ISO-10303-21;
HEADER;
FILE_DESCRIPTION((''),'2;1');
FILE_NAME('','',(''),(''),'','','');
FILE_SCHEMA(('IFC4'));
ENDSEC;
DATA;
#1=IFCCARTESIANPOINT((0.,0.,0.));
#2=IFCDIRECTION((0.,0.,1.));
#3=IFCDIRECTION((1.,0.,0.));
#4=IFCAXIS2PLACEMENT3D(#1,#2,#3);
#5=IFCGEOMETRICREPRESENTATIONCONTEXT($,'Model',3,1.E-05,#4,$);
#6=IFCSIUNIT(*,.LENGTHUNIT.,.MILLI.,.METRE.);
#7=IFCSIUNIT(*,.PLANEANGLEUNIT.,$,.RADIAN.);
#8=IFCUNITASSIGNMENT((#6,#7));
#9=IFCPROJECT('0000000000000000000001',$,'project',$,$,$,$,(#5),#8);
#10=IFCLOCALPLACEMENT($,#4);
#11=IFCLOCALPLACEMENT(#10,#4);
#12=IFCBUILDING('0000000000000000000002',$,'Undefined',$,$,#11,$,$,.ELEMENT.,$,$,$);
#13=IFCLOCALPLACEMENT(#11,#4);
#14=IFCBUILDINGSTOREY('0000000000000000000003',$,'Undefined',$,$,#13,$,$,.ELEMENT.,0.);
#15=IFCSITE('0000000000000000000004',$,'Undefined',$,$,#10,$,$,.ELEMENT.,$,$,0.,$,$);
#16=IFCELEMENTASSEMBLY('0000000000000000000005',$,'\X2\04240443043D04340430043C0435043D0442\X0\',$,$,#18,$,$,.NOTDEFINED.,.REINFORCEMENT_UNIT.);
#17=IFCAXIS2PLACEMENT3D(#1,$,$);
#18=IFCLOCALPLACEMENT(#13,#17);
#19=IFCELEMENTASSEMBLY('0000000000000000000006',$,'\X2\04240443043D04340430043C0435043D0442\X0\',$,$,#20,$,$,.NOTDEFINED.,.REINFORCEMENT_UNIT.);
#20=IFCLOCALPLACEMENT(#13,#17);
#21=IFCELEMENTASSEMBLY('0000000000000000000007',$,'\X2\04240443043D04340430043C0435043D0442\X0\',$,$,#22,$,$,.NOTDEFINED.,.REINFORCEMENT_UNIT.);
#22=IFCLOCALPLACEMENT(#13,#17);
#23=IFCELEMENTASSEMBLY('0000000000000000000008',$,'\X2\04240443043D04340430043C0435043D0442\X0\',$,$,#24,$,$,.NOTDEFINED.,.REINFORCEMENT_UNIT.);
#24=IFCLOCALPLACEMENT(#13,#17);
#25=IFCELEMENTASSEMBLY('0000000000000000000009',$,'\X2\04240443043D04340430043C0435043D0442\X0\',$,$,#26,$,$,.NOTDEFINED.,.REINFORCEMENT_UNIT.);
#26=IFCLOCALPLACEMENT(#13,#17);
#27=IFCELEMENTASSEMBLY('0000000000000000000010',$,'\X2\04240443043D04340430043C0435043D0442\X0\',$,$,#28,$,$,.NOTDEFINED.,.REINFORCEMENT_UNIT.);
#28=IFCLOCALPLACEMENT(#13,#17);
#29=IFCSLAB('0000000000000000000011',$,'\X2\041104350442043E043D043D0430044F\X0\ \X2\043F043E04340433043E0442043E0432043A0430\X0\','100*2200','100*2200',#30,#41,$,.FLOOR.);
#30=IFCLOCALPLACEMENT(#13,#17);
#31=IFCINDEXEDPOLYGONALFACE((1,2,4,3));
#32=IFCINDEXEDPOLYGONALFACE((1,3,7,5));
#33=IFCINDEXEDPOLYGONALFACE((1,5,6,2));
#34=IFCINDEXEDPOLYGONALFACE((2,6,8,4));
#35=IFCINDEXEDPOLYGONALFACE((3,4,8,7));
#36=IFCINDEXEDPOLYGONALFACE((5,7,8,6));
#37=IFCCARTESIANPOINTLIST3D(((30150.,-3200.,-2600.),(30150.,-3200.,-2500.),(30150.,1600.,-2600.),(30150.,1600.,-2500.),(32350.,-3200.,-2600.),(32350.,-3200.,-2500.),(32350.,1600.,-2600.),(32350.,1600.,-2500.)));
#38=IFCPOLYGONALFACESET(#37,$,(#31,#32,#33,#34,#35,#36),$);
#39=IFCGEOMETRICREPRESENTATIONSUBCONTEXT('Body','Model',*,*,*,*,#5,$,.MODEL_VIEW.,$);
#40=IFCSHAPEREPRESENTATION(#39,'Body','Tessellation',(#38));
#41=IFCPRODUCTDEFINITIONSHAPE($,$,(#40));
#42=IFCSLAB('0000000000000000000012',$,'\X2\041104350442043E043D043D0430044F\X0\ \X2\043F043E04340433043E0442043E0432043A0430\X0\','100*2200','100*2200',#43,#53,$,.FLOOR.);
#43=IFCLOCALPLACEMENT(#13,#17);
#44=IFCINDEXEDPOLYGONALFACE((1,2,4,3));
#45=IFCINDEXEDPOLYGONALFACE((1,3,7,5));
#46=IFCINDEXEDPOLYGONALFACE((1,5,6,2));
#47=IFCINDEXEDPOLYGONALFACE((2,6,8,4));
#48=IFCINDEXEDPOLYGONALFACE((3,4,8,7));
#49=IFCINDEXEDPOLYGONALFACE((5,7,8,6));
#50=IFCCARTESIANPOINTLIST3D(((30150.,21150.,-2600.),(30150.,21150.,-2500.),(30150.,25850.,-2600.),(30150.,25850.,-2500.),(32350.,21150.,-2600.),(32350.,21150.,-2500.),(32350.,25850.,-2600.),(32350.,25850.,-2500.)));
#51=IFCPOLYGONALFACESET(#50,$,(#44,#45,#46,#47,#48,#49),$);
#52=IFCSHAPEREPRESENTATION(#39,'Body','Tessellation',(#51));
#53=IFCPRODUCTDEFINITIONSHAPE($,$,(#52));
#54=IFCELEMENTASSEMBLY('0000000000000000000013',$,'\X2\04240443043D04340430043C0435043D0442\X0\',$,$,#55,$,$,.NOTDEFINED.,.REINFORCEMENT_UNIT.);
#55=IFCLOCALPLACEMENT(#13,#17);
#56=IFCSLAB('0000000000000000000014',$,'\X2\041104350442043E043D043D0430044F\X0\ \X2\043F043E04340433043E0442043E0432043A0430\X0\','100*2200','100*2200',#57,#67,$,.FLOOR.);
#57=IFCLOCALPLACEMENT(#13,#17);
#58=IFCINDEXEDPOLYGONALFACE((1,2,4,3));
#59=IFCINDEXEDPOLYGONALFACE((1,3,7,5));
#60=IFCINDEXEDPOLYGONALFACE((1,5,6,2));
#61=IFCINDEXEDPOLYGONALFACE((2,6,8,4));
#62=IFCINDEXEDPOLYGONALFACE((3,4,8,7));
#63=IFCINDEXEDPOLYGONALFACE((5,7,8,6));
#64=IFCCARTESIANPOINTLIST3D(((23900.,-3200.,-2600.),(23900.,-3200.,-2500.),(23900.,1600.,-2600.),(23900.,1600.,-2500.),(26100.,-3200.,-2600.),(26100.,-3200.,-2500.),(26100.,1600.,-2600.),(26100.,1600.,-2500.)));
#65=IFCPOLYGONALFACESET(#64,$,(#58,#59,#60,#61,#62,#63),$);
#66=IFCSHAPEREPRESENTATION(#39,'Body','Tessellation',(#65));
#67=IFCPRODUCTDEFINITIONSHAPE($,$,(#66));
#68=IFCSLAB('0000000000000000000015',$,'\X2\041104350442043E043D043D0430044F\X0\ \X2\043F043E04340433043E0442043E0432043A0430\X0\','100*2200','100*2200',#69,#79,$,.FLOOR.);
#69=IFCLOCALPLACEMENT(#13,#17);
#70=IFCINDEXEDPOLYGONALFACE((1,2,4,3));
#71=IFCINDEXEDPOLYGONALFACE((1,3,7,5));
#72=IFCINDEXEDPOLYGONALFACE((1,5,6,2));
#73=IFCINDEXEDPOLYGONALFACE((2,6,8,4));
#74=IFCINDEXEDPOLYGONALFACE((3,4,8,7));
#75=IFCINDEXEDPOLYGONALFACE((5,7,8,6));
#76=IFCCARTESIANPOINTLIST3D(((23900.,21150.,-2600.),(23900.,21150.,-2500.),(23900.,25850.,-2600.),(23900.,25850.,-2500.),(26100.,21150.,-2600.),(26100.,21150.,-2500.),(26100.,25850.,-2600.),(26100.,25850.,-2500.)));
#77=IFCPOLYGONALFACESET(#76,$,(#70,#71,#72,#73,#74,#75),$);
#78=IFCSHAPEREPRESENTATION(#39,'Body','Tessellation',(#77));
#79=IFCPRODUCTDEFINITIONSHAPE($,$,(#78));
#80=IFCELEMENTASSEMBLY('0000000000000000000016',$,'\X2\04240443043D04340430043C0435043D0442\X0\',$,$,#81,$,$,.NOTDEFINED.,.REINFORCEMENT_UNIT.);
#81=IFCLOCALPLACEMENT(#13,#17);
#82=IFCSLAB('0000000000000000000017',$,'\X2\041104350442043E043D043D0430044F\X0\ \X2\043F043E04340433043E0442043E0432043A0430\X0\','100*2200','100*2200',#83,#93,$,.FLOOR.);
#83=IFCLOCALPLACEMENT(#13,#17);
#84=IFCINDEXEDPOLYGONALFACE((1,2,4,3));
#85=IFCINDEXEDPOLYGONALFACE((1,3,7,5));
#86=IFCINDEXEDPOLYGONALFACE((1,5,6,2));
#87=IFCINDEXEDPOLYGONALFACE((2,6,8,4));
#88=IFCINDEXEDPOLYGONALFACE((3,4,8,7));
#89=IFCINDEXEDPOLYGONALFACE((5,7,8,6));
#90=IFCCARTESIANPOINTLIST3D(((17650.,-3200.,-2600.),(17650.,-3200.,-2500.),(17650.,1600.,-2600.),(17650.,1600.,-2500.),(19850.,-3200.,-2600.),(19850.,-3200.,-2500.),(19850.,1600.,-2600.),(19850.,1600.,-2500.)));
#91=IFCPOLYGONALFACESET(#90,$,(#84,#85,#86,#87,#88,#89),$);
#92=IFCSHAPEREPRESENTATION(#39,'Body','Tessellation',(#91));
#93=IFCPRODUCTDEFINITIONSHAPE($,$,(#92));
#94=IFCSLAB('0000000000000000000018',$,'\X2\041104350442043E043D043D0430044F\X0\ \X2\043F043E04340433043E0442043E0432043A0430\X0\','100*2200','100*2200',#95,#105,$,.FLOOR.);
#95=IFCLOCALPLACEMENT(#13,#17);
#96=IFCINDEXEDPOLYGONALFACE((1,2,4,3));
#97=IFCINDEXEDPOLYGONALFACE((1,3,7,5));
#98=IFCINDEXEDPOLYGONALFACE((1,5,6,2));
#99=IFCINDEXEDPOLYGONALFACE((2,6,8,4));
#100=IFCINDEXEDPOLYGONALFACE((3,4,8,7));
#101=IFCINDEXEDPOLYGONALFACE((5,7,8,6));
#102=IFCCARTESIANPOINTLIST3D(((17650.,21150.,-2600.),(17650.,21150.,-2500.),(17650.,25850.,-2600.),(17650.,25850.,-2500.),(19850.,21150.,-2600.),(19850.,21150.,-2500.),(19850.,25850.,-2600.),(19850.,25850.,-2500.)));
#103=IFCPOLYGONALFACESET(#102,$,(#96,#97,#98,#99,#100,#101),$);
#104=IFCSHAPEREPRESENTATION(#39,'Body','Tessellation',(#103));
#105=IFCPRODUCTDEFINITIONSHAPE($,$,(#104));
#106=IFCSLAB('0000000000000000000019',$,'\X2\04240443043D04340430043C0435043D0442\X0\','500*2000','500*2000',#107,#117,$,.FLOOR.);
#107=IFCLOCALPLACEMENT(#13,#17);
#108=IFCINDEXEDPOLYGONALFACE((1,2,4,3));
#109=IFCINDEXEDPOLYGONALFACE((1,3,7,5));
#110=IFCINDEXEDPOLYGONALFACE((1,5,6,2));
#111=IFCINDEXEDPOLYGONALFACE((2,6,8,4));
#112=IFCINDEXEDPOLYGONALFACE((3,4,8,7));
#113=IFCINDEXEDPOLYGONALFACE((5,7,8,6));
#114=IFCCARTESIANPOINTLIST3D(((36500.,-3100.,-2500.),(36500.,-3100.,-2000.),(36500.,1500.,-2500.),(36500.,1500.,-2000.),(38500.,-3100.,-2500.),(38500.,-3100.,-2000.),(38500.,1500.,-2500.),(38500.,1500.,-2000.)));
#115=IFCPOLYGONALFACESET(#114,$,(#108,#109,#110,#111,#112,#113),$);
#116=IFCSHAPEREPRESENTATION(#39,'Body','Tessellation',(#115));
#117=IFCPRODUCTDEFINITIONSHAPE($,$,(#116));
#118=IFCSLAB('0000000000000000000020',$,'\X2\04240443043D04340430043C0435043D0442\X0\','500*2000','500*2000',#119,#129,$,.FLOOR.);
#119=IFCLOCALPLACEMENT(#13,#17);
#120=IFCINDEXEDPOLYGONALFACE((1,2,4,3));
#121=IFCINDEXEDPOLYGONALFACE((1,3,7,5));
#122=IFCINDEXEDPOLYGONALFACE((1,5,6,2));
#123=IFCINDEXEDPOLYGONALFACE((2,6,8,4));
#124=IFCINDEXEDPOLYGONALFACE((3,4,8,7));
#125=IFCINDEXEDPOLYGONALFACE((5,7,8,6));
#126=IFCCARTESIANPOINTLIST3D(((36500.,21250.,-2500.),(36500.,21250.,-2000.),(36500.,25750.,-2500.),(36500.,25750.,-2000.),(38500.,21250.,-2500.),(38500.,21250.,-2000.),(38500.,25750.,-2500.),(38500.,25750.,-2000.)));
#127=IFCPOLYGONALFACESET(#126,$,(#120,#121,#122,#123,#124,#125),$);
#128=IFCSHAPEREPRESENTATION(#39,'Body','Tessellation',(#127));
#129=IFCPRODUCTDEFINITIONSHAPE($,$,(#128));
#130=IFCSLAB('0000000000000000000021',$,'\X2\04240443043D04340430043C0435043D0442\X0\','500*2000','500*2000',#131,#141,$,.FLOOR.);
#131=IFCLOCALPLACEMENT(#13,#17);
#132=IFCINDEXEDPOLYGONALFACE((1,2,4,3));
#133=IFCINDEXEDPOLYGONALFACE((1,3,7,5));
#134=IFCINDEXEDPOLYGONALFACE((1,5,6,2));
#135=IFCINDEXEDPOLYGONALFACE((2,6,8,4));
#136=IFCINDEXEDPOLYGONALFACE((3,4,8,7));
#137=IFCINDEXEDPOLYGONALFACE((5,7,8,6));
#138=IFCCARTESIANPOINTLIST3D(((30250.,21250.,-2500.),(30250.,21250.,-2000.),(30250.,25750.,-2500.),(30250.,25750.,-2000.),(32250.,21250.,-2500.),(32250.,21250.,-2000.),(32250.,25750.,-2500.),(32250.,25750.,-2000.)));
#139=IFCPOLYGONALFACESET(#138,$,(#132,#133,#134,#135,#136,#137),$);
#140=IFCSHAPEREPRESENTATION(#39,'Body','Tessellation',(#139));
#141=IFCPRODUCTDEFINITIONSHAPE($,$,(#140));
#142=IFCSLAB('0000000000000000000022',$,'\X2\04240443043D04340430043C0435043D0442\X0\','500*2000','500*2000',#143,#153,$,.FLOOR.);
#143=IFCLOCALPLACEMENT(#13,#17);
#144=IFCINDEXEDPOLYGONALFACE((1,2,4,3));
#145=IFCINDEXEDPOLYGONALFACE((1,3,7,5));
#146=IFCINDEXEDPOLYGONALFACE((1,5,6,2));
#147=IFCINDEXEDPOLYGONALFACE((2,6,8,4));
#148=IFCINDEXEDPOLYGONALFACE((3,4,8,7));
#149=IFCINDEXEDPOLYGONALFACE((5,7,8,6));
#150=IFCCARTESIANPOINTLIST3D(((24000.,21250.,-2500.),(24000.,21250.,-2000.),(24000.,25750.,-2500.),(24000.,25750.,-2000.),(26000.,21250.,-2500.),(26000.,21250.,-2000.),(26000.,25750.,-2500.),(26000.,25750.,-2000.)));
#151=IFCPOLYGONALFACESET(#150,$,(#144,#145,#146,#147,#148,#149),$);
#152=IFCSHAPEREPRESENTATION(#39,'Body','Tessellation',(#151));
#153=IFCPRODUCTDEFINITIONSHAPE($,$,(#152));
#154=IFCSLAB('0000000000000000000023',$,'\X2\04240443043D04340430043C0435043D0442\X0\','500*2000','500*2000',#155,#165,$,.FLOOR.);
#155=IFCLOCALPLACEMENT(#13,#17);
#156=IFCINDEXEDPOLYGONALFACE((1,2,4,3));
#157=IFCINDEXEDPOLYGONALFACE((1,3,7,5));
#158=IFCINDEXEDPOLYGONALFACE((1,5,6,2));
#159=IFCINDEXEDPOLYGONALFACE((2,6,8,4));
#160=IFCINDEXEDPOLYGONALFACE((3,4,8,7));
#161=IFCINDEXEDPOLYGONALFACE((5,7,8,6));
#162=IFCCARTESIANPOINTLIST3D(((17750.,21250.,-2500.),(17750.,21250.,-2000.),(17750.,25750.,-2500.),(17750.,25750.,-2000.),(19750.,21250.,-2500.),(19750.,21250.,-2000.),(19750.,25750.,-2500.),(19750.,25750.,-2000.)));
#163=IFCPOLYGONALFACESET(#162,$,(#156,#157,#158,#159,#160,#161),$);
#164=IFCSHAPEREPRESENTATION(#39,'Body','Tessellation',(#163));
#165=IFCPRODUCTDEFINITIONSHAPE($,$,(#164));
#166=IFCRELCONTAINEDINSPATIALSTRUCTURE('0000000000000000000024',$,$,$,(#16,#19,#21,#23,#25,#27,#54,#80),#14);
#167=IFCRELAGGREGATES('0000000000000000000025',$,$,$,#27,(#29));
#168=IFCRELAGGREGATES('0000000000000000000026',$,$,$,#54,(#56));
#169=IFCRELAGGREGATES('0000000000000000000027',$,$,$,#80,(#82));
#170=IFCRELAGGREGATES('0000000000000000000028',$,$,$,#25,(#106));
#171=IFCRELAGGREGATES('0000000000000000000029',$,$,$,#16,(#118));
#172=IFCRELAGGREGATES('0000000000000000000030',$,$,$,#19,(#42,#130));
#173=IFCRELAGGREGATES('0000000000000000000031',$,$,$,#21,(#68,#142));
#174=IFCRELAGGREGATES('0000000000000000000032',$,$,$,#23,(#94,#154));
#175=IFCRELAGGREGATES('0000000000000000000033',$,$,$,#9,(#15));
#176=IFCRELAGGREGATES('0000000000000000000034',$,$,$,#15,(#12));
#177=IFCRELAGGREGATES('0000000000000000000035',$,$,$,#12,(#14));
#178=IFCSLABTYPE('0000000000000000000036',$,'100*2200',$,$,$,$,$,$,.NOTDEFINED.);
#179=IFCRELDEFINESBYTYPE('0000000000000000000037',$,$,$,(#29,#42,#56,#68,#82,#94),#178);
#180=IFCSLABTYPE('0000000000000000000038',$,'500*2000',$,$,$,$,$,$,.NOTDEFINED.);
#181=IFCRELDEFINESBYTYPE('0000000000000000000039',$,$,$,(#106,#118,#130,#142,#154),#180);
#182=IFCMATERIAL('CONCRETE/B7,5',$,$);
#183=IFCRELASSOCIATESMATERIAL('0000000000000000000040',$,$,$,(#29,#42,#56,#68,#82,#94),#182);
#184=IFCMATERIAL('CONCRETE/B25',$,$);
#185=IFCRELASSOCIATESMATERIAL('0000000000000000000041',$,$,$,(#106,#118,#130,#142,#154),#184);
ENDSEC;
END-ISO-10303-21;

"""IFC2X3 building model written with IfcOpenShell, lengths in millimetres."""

from ifc_helpers import new_model, si_unit, frame, origin_with_axes, place, context, subcontext, project, spatial, polyline, outline, extrude, material, type_object, element, aggregate, save


model = new_model("IFC2X3")

# Units and contexts
model_context = context("Model", 3, precision=1e-05, world=origin_with_axes())
body_context = subcontext(model_context, "Body", "Model", "MODEL_VIEW")
ifc_project = project(units=[si_unit("LENGTHUNIT", "METRE", prefix="MILLI"), si_unit("PLANEANGLEUNIT", "RADIAN")], contexts=[model_context])

# Site, building, storey
site_placement = place(None, origin_with_axes())
site = spatial("IfcSite", under=ifc_project, at=site_placement, Name="Undefined", CompositionType="ELEMENT", RefElevation=0.0)
building_placement = place(site_placement, origin_with_axes())
building = spatial("IfcBuilding", under=site, at=building_placement, Name="Undefined", CompositionType="ELEMENT")
storey_placement = place(building_placement, origin_with_axes())
storey = spatial("IfcBuildingStorey", under=building, at=storey_placement, Name="Undefined", CompositionType="ELEMENT", Elevation=0.0)

# Element assemblies
ifc_material_1 = material(Name="CONCRETE/B25")
assembly_1_placement = place(storey_placement, origin_with_axes())
assembly_1 = element("IfcElementAssembly", 1, at=assembly_1_placement, inside=storey, Name="Фундамент", AssemblyPlace="NOTDEFINED", PredefinedType="REINFORCEMENT_UNIT")
assembly_2_placement = place(storey_placement, origin_with_axes())
assembly_2 = element("IfcElementAssembly", 2, at=assembly_2_placement, inside=storey, Name="Фундамент", AssemblyPlace="NOTDEFINED", PredefinedType="REINFORCEMENT_UNIT")
assembly_3_placement = place(storey_placement, origin_with_axes())
assembly_3 = element("IfcElementAssembly", 3, at=assembly_3_placement, inside=storey, Name="Фундамент", AssemblyPlace="NOTDEFINED", PredefinedType="REINFORCEMENT_UNIT")
assembly_4_placement = place(storey_placement, origin_with_axes())
assembly_4 = element("IfcElementAssembly", 4, at=assembly_4_placement, inside=storey, Name="Фундамент", AssemblyPlace="NOTDEFINED", PredefinedType="REINFORCEMENT_UNIT")

# Element assembly
assembly_5_placement = place(storey_placement, origin_with_axes())
assembly_5 = element("IfcElementAssembly", 5, at=assembly_5_placement, inside=storey, Name="Фундамент", AssemblyPlace="NOTDEFINED", PredefinedType="REINFORCEMENT_UNIT")
ifc_material_2 = material(Name="CONCRETE/B7,5")
slab_type_1 = type_object("IfcSlabType", Name="100*2200", PredefinedType="NOTDEFINED")

# Element assembly, slab
assembly_6_placement = place(storey_placement, origin_with_axes())
assembly_6 = element("IfcElementAssembly", 6, at=assembly_6_placement, inside=storey, Name="Фундамент", AssemblyPlace="NOTDEFINED", PredefinedType="REINFORCEMENT_UNIT")
slab_1_placement = place(assembly_6_placement, frame((30150.0, 1600.0, -2550.0), z_axis=(0.0, 0.0, 1.0), x_axis=(0.0, -1.0, 0.0)))
slab_1 = element("IfcSlab", 7, at=slab_1_placement, type_object=slab_type_1, material=ifc_material_2, Name="Бетонная подготовка", Description="100*2200", ObjectType="100*2200", PredefinedType="FLOOR", context=body_context, shape_type="SweptSolid", body=[
    extrude(outline(polyline([(0.0, 0.0), (4800.0, 0.0), (4800.0, 2200.0), (0.0, 2200.0), (0.0, 0.0)])), frame((0.0, 0.0, -50.0), z_axis=(0.0, 0.0, 1.0), x_axis=(1.0, 0.0, 0.0)), (0.0, 0.0, 1.0), 100.0),
])
aggregate(assembly_6, [slab_1])

# Slab
slab_2_placement = place(assembly_2_placement, frame((30150.0, 25850.0, -2550.0), z_axis=(0.0, 0.0, 1.0), x_axis=(0.0, -1.0, 0.0)))
slab_2 = element("IfcSlab", 8, at=slab_2_placement, type_object=slab_type_1, material=ifc_material_2, Name="Бетонная подготовка", Description="100*2200", ObjectType="100*2200", PredefinedType="FLOOR", context=body_context, shape_type="SweptSolid", body=[
    extrude(outline(polyline([(0.0, 0.0), (4700.0, 0.0), (4700.0, 2200.0), (0.0, 2200.0), (0.0, 0.0)])), frame((0.0, 0.0, -50.0), z_axis=(0.0, 0.0, 1.0), x_axis=(1.0, 0.0, 0.0)), (0.0, 0.0, 1.0), 100.0),
])

# Element assembly, slab
assembly_7_placement = place(storey_placement, origin_with_axes())
assembly_7 = element("IfcElementAssembly", 9, at=assembly_7_placement, inside=storey, Name="Фундамент", AssemblyPlace="NOTDEFINED", PredefinedType="REINFORCEMENT_UNIT")
slab_3_placement = place(assembly_7_placement, frame((23900.0, 1600.0, -2550.0), z_axis=(0.0, 0.0, 1.0), x_axis=(0.0, -1.0, 0.0)))
slab_3 = element("IfcSlab", 10, at=slab_3_placement, type_object=slab_type_1, material=ifc_material_2, Name="Бетонная подготовка", Description="100*2200", ObjectType="100*2200", PredefinedType="FLOOR", context=body_context, shape_type="SweptSolid", body=[
    extrude(outline(polyline([(0.0, 0.0), (4800.0, 0.0), (4800.0, 2200.0), (0.0, 2200.0), (0.0, 0.0)])), frame((0.0, 0.0, -50.0), z_axis=(0.0, 0.0, 1.0), x_axis=(1.0, 0.0, 0.0)), (0.0, 0.0, 1.0), 100.0),
])
aggregate(assembly_7, [slab_3])

# Slab
slab_4_placement = place(assembly_3_placement, frame((23900.0, 25850.0, -2550.0), z_axis=(0.0, 0.0, 1.0), x_axis=(0.0, -1.0, 0.0)))
slab_4 = element("IfcSlab", 11, at=slab_4_placement, type_object=slab_type_1, material=ifc_material_2, Name="Бетонная подготовка", Description="100*2200", ObjectType="100*2200", PredefinedType="FLOOR", context=body_context, shape_type="SweptSolid", body=[
    extrude(outline(polyline([(0.0, 0.0), (4700.0, 0.0), (4700.0, 2200.0), (0.0, 2200.0), (0.0, 0.0)])), frame((0.0, 0.0, -50.0), z_axis=(0.0, 0.0, 1.0), x_axis=(1.0, 0.0, 0.0)), (0.0, 0.0, 1.0), 100.0),
])

# Element assembly, slab
assembly_8_placement = place(storey_placement, origin_with_axes())
assembly_8 = element("IfcElementAssembly", 12, at=assembly_8_placement, inside=storey, Name="Фундамент", AssemblyPlace="NOTDEFINED", PredefinedType="REINFORCEMENT_UNIT")
slab_5_placement = place(assembly_8_placement, frame((17650.0, 1600.0, -2550.0), z_axis=(0.0, 0.0, 1.0), x_axis=(0.0, -1.0, 0.0)))
slab_5 = element("IfcSlab", 13, at=slab_5_placement, type_object=slab_type_1, material=ifc_material_2, Name="Бетонная подготовка", Description="100*2200", ObjectType="100*2200", PredefinedType="FLOOR", context=body_context, shape_type="SweptSolid", body=[
    extrude(outline(polyline([(0.0, 0.0), (4800.0, 0.0), (4800.0, 2200.0), (0.0, 2200.0), (0.0, 0.0)])), frame((0.0, 0.0, -50.0), z_axis=(0.0, 0.0, 1.0), x_axis=(1.0, 0.0, 0.0)), (0.0, 0.0, 1.0), 100.0),
])
aggregate(assembly_8, [slab_5])

# Slabs
slab_6_placement = place(assembly_4_placement, frame((17650.0, 25850.0, -2550.0), z_axis=(0.0, 0.0, 1.0), x_axis=(0.0, -1.0, 0.0)))
slab_6 = element("IfcSlab", 14, at=slab_6_placement, type_object=slab_type_1, material=ifc_material_2, Name="Бетонная подготовка", Description="100*2200", ObjectType="100*2200", PredefinedType="FLOOR", context=body_context, shape_type="SweptSolid", body=[
    extrude(outline(polyline([(0.0, 0.0), (4700.0, 0.0), (4700.0, 2200.0), (0.0, 2200.0), (0.0, 0.0)])), frame((0.0, 0.0, -50.0), z_axis=(0.0, 0.0, 1.0), x_axis=(1.0, 0.0, 0.0)), (0.0, 0.0, 1.0), 100.0),
])
slab_type_2 = type_object("IfcSlabType", Name="500*2000", PredefinedType="NOTDEFINED")
slab_7_placement = place(assembly_5_placement, frame((36500.0, 1500.0, -2250.0), z_axis=(0.0, 0.0, 1.0), x_axis=(0.0, -1.0, 0.0)))
slab_7 = element("IfcSlab", 15, at=slab_7_placement, type_object=slab_type_2, material=ifc_material_1, Name="Фундамент", Description="500*2000", ObjectType="500*2000", PredefinedType="FLOOR", context=body_context, shape_type="SweptSolid", body=[
    extrude(outline(polyline([(0.0, 0.0), (4600.0, 0.0), (4600.0, 2000.0), (0.0, 2000.0), (0.0, 0.0)])), frame((0.0, 0.0, -250.0), z_axis=(0.0, 0.0, 1.0), x_axis=(1.0, 0.0, 0.0)), (0.0, 0.0, 1.0), 500.0),
])
aggregate(assembly_5, [slab_7])
slab_8_placement = place(assembly_1_placement, frame((36500.0, 25750.0, -2250.0), z_axis=(0.0, 0.0, 1.0), x_axis=(0.0, -1.0, 0.0)))
slab_8 = element("IfcSlab", 16, at=slab_8_placement, type_object=slab_type_2, material=ifc_material_1, Name="Фундамент", Description="500*2000", ObjectType="500*2000", PredefinedType="FLOOR", context=body_context, shape_type="SweptSolid", body=[
    extrude(outline(polyline([(0.0, 0.0), (4500.0, 0.0), (4500.0, 2000.0), (0.0, 2000.0), (0.0, 0.0)])), frame((0.0, 0.0, -250.0), z_axis=(0.0, 0.0, 1.0), x_axis=(1.0, 0.0, 0.0)), (0.0, 0.0, 1.0), 500.0),
])
aggregate(assembly_1, [slab_8])
slab_9_placement = place(assembly_2_placement, frame((30250.0, 25750.0, -2250.0), z_axis=(0.0, 0.0, 1.0), x_axis=(0.0, -1.0, 0.0)))
slab_9 = element("IfcSlab", 17, at=slab_9_placement, type_object=slab_type_2, material=ifc_material_1, Name="Фундамент", Description="500*2000", ObjectType="500*2000", PredefinedType="FLOOR", context=body_context, shape_type="SweptSolid", body=[
    extrude(outline(polyline([(0.0, 0.0), (4500.0, 0.0), (4500.0, 2000.0), (0.0, 2000.0), (0.0, 0.0)])), frame((0.0, 0.0, -250.0), z_axis=(0.0, 0.0, 1.0), x_axis=(1.0, 0.0, 0.0)), (0.0, 0.0, 1.0), 500.0),
])
aggregate(assembly_2, [slab_2, slab_9])
slab_10_placement = place(assembly_3_placement, frame((24000.0, 25750.0, -2250.0), z_axis=(0.0, 0.0, 1.0), x_axis=(0.0, -1.0, 0.0)))
slab_10 = element("IfcSlab", 18, at=slab_10_placement, type_object=slab_type_2, material=ifc_material_1, Name="Фундамент", Description="500*2000", ObjectType="500*2000", PredefinedType="FLOOR", context=body_context, shape_type="SweptSolid", body=[
    extrude(outline(polyline([(0.0, 0.0), (4500.0, 0.0), (4500.0, 2000.0), (0.0, 2000.0), (0.0, 0.0)])), frame((0.0, 0.0, -250.0), z_axis=(0.0, 0.0, 1.0), x_axis=(1.0, 0.0, 0.0)), (0.0, 0.0, 1.0), 500.0),
])
aggregate(assembly_3, [slab_4, slab_10])
slab_11_placement = place(assembly_4_placement, frame((17750.0, 25750.0, -2250.0), z_axis=(0.0, 0.0, 1.0), x_axis=(0.0, -1.0, 0.0)))
slab_11 = element("IfcSlab", 19, at=slab_11_placement, type_object=slab_type_2, material=ifc_material_1, Name="Фундамент", Description="500*2000", ObjectType="500*2000", PredefinedType="FLOOR", context=body_context, shape_type="SweptSolid", body=[
    extrude(outline(polyline([(0.0, 0.0), (4500.0, 0.0), (4500.0, 2000.0), (0.0, 2000.0), (0.0, 0.0)])), frame((0.0, 0.0, -250.0), z_axis=(0.0, 0.0, 1.0), x_axis=(1.0, 0.0, 0.0)), (0.0, 0.0, 1.0), 500.0),
])
aggregate(assembly_4, [slab_6, slab_11])

save(model, "model.ifc")
